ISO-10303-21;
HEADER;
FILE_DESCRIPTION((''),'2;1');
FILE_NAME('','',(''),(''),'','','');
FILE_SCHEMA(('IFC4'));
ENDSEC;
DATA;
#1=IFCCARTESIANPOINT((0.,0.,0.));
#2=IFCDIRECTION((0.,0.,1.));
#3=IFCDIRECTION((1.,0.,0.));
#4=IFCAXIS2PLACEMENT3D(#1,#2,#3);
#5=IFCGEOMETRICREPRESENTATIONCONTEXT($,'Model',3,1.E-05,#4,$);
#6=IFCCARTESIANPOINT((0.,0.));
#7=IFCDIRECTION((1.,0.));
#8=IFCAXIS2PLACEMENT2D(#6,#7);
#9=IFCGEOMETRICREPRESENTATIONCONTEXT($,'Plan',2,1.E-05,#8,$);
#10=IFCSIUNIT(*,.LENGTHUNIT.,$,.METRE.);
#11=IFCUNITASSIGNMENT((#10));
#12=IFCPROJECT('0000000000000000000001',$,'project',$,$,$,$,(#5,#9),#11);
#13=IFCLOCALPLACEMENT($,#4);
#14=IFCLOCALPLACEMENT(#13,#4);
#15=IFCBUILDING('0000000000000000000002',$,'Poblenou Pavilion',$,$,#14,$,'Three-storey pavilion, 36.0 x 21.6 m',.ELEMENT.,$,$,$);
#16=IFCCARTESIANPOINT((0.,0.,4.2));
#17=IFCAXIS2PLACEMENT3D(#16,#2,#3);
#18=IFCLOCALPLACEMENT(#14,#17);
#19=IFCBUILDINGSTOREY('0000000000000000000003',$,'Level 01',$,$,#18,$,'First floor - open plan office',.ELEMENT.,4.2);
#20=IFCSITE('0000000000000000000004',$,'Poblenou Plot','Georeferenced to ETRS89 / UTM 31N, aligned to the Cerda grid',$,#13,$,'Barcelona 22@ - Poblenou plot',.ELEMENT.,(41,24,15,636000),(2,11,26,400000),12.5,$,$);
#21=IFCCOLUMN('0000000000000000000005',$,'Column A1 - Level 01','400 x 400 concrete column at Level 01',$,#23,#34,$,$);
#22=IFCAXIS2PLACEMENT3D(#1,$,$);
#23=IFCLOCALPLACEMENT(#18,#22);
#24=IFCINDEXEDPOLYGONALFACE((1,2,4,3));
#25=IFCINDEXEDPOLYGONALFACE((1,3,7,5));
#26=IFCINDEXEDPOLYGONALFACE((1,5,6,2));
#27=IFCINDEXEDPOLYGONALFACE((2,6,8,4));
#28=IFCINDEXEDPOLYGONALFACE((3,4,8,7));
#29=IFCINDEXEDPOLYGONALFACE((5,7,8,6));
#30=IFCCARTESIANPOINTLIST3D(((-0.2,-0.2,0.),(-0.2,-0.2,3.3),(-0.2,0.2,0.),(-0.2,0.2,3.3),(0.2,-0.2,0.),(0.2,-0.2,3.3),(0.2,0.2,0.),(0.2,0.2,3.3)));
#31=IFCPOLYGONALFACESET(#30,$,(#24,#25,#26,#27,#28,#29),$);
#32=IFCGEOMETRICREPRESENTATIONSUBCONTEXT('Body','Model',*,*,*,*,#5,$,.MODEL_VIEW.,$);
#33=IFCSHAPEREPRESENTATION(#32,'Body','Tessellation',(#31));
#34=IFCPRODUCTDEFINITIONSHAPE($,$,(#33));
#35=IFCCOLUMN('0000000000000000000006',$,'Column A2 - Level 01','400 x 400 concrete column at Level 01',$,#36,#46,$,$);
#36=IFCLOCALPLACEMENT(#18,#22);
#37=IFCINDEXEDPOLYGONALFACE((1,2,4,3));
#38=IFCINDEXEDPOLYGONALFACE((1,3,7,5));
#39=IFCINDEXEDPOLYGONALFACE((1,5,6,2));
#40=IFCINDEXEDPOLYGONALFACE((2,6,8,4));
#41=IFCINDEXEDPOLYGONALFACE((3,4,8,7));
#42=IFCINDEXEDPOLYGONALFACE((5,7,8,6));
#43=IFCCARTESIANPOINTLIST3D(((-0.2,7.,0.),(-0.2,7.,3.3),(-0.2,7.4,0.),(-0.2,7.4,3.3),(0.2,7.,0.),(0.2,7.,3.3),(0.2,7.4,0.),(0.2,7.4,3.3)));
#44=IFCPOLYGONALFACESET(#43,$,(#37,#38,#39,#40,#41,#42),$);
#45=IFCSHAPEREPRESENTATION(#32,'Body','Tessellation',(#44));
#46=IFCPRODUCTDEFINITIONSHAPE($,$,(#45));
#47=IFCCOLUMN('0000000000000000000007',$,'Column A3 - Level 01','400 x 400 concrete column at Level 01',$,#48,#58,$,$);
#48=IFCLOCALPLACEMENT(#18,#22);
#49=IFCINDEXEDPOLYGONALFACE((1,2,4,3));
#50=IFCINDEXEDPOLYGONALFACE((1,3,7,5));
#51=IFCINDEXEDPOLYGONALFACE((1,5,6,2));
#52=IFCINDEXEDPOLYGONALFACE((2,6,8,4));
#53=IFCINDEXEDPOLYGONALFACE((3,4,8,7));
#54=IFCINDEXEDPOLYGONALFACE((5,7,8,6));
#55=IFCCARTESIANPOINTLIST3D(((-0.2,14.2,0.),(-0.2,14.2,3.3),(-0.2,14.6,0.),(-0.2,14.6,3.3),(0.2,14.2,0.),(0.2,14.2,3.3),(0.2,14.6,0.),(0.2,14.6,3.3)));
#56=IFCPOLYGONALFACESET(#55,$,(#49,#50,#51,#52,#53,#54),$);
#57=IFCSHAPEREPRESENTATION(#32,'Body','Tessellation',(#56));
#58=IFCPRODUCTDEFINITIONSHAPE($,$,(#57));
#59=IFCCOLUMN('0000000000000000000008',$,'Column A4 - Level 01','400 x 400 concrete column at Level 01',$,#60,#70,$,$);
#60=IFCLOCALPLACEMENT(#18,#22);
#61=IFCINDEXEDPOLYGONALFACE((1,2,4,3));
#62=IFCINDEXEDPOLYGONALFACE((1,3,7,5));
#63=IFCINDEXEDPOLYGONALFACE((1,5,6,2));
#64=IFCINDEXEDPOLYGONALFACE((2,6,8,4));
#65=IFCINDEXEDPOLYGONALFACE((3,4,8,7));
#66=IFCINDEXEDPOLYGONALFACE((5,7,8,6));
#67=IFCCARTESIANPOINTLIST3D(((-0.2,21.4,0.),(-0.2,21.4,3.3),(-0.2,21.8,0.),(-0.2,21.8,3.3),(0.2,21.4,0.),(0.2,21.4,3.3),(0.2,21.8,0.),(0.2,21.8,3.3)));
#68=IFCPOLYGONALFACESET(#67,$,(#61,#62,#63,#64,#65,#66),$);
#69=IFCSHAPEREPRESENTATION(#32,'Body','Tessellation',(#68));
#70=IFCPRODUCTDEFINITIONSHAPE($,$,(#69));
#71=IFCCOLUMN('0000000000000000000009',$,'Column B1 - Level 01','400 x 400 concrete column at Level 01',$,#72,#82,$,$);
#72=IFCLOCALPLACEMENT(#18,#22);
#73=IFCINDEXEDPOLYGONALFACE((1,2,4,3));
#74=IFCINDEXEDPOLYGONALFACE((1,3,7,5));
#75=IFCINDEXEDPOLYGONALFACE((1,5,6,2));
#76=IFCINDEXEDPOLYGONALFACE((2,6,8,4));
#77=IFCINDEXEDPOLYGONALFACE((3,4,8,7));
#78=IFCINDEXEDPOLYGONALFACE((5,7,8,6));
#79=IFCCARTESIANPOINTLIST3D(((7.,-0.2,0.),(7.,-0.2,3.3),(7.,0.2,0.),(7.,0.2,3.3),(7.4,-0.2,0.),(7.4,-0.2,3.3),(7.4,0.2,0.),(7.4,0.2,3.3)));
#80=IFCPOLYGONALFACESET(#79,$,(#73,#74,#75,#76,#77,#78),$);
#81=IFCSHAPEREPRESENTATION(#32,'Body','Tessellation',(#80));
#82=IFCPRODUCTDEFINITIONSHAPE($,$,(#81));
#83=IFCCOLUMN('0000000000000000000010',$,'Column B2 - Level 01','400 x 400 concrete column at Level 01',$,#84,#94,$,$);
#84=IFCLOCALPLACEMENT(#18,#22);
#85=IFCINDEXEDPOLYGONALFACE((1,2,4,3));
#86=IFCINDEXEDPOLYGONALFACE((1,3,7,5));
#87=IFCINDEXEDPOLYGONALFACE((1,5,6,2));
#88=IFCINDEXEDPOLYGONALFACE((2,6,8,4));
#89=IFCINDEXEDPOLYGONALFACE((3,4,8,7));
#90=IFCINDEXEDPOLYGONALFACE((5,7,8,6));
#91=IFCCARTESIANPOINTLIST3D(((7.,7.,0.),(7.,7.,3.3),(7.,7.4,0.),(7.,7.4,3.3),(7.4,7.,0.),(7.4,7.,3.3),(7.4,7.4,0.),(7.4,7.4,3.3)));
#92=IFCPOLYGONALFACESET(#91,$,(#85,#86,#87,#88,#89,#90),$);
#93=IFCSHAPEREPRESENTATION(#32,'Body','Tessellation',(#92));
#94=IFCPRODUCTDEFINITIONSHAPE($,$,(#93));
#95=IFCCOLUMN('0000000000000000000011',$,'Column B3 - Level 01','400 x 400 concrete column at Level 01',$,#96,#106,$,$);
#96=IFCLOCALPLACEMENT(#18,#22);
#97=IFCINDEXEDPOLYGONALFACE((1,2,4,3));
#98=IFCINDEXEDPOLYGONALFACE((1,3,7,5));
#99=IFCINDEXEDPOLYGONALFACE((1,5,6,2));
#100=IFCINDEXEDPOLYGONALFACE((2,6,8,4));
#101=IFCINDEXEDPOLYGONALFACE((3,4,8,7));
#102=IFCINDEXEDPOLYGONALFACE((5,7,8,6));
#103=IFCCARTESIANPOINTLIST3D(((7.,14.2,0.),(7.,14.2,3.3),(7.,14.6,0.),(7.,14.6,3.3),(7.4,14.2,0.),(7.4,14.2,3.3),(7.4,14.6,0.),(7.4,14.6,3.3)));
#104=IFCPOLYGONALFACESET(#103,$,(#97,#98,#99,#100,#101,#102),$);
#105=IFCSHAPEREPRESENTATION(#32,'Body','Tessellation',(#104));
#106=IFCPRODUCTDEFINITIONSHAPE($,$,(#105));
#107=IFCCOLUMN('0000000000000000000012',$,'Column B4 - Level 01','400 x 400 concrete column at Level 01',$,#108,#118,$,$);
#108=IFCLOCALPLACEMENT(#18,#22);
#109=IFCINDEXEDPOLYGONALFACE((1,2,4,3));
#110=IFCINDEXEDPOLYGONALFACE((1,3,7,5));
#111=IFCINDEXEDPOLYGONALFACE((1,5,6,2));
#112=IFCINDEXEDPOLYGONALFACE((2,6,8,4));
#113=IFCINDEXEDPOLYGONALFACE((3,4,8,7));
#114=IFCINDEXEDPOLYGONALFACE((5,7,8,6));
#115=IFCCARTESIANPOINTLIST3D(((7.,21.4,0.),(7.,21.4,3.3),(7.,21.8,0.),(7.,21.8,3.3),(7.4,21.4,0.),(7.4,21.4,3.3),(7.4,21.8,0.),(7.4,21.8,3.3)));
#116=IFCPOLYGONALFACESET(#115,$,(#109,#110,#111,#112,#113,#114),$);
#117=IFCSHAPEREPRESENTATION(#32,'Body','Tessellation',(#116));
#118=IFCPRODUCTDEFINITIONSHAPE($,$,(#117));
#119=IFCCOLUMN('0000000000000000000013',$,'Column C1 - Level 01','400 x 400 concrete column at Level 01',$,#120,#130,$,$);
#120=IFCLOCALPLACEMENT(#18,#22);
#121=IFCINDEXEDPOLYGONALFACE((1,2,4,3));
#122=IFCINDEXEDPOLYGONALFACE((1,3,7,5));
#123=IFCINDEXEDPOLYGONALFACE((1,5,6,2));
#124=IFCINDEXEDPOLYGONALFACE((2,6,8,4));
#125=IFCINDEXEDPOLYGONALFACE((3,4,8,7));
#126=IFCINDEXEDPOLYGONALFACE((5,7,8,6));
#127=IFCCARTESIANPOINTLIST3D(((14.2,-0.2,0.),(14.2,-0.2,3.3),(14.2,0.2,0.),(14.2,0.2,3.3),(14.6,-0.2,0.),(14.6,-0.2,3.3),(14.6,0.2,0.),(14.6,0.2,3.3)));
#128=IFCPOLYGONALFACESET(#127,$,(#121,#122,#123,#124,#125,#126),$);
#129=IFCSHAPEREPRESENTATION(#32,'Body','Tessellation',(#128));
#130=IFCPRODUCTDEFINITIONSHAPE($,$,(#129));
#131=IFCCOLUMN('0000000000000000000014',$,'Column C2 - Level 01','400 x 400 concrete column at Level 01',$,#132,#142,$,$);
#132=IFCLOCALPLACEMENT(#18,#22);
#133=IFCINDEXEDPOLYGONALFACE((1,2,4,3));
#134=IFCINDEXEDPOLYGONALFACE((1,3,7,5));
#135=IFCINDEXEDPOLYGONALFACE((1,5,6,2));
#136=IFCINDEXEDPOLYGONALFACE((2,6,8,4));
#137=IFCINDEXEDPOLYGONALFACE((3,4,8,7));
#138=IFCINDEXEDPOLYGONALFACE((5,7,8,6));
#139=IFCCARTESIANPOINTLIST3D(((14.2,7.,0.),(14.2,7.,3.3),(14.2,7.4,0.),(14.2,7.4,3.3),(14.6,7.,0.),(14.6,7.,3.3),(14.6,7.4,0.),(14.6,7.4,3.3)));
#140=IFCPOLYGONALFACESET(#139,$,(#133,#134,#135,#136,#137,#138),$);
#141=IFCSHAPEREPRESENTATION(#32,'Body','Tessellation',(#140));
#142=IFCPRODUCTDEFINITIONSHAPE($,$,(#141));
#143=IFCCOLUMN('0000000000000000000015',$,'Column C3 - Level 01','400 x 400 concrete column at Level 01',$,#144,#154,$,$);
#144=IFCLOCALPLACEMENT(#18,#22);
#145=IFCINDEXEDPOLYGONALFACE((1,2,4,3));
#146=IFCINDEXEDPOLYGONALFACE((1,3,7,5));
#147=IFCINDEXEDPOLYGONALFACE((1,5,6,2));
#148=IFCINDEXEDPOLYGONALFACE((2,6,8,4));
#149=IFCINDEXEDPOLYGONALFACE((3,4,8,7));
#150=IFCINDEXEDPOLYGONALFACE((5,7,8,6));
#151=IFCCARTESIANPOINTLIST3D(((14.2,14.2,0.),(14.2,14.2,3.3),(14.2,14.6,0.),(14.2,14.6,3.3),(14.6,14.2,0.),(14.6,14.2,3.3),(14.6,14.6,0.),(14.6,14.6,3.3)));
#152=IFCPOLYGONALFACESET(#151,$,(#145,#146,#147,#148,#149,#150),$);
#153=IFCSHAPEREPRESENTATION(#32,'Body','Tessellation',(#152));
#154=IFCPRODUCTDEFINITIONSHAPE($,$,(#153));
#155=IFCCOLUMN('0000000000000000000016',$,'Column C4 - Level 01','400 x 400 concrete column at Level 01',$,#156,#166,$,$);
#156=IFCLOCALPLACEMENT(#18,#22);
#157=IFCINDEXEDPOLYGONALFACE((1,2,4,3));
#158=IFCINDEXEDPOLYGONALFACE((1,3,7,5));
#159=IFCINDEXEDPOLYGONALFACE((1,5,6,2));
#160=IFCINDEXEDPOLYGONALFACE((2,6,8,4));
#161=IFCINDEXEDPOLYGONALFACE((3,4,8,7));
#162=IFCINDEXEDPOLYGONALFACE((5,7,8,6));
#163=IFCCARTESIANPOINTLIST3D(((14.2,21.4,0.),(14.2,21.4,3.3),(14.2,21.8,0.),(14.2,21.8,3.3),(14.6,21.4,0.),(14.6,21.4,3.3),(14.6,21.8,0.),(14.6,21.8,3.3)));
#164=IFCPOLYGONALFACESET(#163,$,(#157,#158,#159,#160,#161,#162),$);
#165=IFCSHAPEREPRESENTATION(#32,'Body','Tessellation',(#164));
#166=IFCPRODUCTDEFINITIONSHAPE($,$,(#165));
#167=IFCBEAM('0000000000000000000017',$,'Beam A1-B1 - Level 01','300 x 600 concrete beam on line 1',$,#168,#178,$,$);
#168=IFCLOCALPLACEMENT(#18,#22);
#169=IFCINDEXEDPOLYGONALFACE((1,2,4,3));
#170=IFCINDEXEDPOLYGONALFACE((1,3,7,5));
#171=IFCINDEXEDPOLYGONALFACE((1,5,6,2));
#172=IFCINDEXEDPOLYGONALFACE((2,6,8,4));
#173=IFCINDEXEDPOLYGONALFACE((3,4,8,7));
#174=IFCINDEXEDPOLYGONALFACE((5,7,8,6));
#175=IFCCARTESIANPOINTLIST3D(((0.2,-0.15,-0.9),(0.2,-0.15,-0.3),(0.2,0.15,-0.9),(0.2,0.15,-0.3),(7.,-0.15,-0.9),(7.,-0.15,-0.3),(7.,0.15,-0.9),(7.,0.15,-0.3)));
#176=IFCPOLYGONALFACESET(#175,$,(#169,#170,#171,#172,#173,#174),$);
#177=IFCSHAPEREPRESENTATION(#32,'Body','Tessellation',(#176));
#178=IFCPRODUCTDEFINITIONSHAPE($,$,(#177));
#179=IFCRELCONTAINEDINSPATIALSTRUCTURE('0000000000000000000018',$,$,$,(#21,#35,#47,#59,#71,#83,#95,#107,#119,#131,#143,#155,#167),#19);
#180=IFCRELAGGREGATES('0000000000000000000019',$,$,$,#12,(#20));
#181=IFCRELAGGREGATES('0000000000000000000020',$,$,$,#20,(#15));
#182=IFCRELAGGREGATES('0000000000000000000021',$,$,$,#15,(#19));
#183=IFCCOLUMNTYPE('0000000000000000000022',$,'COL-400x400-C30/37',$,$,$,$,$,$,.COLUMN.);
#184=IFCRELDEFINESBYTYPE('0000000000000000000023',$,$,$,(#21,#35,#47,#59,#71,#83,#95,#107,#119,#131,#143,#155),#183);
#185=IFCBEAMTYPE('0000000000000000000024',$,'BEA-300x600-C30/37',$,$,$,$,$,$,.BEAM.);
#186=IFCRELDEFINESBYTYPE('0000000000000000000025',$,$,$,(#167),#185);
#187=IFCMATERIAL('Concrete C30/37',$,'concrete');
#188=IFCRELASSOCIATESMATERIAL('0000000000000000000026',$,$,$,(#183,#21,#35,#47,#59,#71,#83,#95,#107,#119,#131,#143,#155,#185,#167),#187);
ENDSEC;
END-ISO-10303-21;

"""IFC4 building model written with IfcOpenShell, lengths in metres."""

from ifc_helpers import new_model, si_unit, frame, origin_with_axes, origin_2d_with_axis, place, context, subcontext, project, spatial, line, indexed_curve, rectangle, outline, extrude, material, material_profile, profile_set, profile_usage, type_object, element, save


model = new_model("IFC4")

# Units and contexts
model_context = context("Model", 3, precision=1e-05, world=origin_with_axes())
plan_context = context("Plan", 2, precision=1e-05, world=origin_2d_with_axis())
body_context = subcontext(model_context, "Body", "Model", "MODEL_VIEW")
ifc_project = project(units=[si_unit("LENGTHUNIT", "METRE")], contexts=[model_context, plan_context])

# Site, building, storey
site_placement = place(None, origin_with_axes())
site = spatial("IfcSite", under=ifc_project, at=site_placement, Name="Poblenou Plot", Description="Georeferenced to ETRS89 / UTM 31N, aligned to the Cerda grid", LongName="Barcelona 22@ - Poblenou plot", CompositionType="ELEMENT", RefLatitude=(41, 24, 15, 636000), RefLongitude=(2, 11, 26, 400000), RefElevation=12.5)
building_placement = place(site_placement, origin_with_axes())
building = spatial("IfcBuilding", under=site, at=building_placement, Name="Poblenou Pavilion", LongName="Three-storey pavilion, 36.0 x 21.6 m", CompositionType="ELEMENT")
storey_placement = place(building_placement, frame((0.0, 0.0, 4.2), z_axis=(0.0, 0.0, 1.0), x_axis=(1.0, 0.0, 0.0)))
storey = spatial("IfcBuildingStorey", under=building, at=storey_placement, Name="Level 01", LongName="First floor - open plan office", CompositionType="ELEMENT", Elevation=4.2)

# Columns
ifc_material = material(Name="Concrete C30/37", Category="concrete")
ifc_material_profile_1 = material_profile(ifc_material, rectangle(XDim=0.4, YDim=0.4))
ifc_profile_set_1 = profile_set([ifc_material_profile_1], Name="COL-400x400-C30/37")
ifc_profile_usage_1 = profile_usage(ifc_profile_set_1)
column_type = type_object("IfcColumnType", Name="COL-400x400-C30/37", PredefinedType="COLUMN", material=ifc_profile_set_1)
column_1_placement = place(storey_placement, frame((-0.2, -0.2, 0.0), z_axis=(0.0, 0.0, 1.0), x_axis=(1.0, 0.0, 0.0)))
element("IfcColumn", 1, at=column_1_placement, inside=storey, type_object=column_type, material=ifc_profile_usage_1, Name="Column A1 - Level 01", Description="400 x 400 concrete column at Level 01", context=body_context, shape_type="SweptSolid", body=[
    extrude(outline(indexed_curve([(0.0, 0.0), (0.4, 0.0), (0.4, 0.4), (0.0, 0.4)], segments=[line(1, 2, 3, 4, 1)])), origin_with_axes(), (0.0, 0.0, 1.0), 3.3),
])
ifc_profile_usage_2 = profile_usage(ifc_profile_set_1)
column_2_placement = place(storey_placement, frame((-0.2, 7.0, 0.0), z_axis=(0.0, 0.0, 1.0), x_axis=(1.0, 0.0, 0.0)))
element("IfcColumn", 2, at=column_2_placement, inside=storey, type_object=column_type, material=ifc_profile_usage_2, Name="Column A2 - Level 01", Description="400 x 400 concrete column at Level 01", context=body_context, shape_type="SweptSolid", body=[
    extrude(outline(indexed_curve([(0.0, 0.0), (0.4, 0.0), (0.4, 0.4), (0.0, 0.4)], segments=[line(1, 2, 3, 4, 1)])), origin_with_axes(), (0.0, 0.0, 1.0), 3.3),
])
ifc_profile_usage_3 = profile_usage(ifc_profile_set_1)
column_3_placement = place(storey_placement, frame((-0.2, 14.2, 0.0), z_axis=(0.0, 0.0, 1.0), x_axis=(1.0, 0.0, 0.0)))
element("IfcColumn", 3, at=column_3_placement, inside=storey, type_object=column_type, material=ifc_profile_usage_3, Name="Column A3 - Level 01", Description="400 x 400 concrete column at Level 01", context=body_context, shape_type="SweptSolid", body=[
    extrude(outline(indexed_curve([(0.0, 0.0), (0.4, 0.0), (0.4, 0.4), (0.0, 0.4)], segments=[line(1, 2, 3, 4, 1)])), origin_with_axes(), (0.0, 0.0, 1.0), 3.3),
])
ifc_profile_usage_4 = profile_usage(ifc_profile_set_1)
column_4_placement = place(storey_placement, frame((-0.2, 21.4, 0.0), z_axis=(0.0, 0.0, 1.0), x_axis=(1.0, 0.0, 0.0)))
element("IfcColumn", 4, at=column_4_placement, inside=storey, type_object=column_type, material=ifc_profile_usage_4, Name="Column A4 - Level 01", Description="400 x 400 concrete column at Level 01", context=body_context, shape_type="SweptSolid", body=[
    extrude(outline(indexed_curve([(0.0, 0.0), (0.4, 0.0), (0.4, 0.4), (0.0, 0.4)], segments=[line(1, 2, 3, 4, 1)])), origin_with_axes(), (0.0, 0.0, 1.0), 3.3),
])
ifc_profile_usage_5 = profile_usage(ifc_profile_set_1)
column_5_placement = place(storey_placement, frame((7.0, -0.2, 0.0), z_axis=(0.0, 0.0, 1.0), x_axis=(1.0, 0.0, 0.0)))
element("IfcColumn", 5, at=column_5_placement, inside=storey, type_object=column_type, material=ifc_profile_usage_5, Name="Column B1 - Level 01", Description="400 x 400 concrete column at Level 01", context=body_context, shape_type="SweptSolid", body=[
    extrude(outline(indexed_curve([(0.0, 0.0), (0.4, 0.0), (0.4, 0.4), (0.0, 0.4)], segments=[line(1, 2, 3, 4, 1)])), origin_with_axes(), (0.0, 0.0, 1.0), 3.3),
])
ifc_profile_usage_6 = profile_usage(ifc_profile_set_1)
column_6_placement = place(storey_placement, frame((7.0, 7.0, 0.0), z_axis=(0.0, 0.0, 1.0), x_axis=(1.0, 0.0, 0.0)))
element("IfcColumn", 6, at=column_6_placement, inside=storey, type_object=column_type, material=ifc_profile_usage_6, Name="Column B2 - Level 01", Description="400 x 400 concrete column at Level 01", context=body_context, shape_type="SweptSolid", body=[
    extrude(outline(indexed_curve([(0.0, 0.0), (0.4, 0.0), (0.4, 0.4), (0.0, 0.4)], segments=[line(1, 2, 3, 4, 1)])), origin_with_axes(), (0.0, 0.0, 1.0), 3.3),
])
ifc_profile_usage_7 = profile_usage(ifc_profile_set_1)
column_7_placement = place(storey_placement, frame((7.0, 14.2, 0.0), z_axis=(0.0, 0.0, 1.0), x_axis=(1.0, 0.0, 0.0)))
element("IfcColumn", 7, at=column_7_placement, inside=storey, type_object=column_type, material=ifc_profile_usage_7, Name="Column B3 - Level 01", Description="400 x 400 concrete column at Level 01", context=body_context, shape_type="SweptSolid", body=[
    extrude(outline(indexed_curve([(0.0, 0.0), (0.4, 0.0), (0.4, 0.4), (0.0, 0.4)], segments=[line(1, 2, 3, 4, 1)])), origin_with_axes(), (0.0, 0.0, 1.0), 3.3),
])
ifc_profile_usage_8 = profile_usage(ifc_profile_set_1)
column_8_placement = place(storey_placement, frame((7.0, 21.4, 0.0), z_axis=(0.0, 0.0, 1.0), x_axis=(1.0, 0.0, 0.0)))
element("IfcColumn", 8, at=column_8_placement, inside=storey, type_object=column_type, material=ifc_profile_usage_8, Name="Column B4 - Level 01", Description="400 x 400 concrete column at Level 01", context=body_context, shape_type="SweptSolid", body=[
    extrude(outline(indexed_curve([(0.0, 0.0), (0.4, 0.0), (0.4, 0.4), (0.0, 0.4)], segments=[line(1, 2, 3, 4, 1)])), origin_with_axes(), (0.0, 0.0, 1.0), 3.3),
])
ifc_profile_usage_9 = profile_usage(ifc_profile_set_1)
column_9_placement = place(storey_placement, frame((14.2, -0.2, 0.0), z_axis=(0.0, 0.0, 1.0), x_axis=(1.0, 0.0, 0.0)))
element("IfcColumn", 9, at=column_9_placement, inside=storey, type_object=column_type, material=ifc_profile_usage_9, Name="Column C1 - Level 01", Description="400 x 400 concrete column at Level 01", context=body_context, shape_type="SweptSolid", body=[
    extrude(outline(indexed_curve([(0.0, 0.0), (0.4, 0.0), (0.4, 0.4), (0.0, 0.4)], segments=[line(1, 2, 3, 4, 1)])), origin_with_axes(), (0.0, 0.0, 1.0), 3.3),
])
ifc_profile_usage_10 = profile_usage(ifc_profile_set_1)
column_10_placement = place(storey_placement, frame((14.2, 7.0, 0.0), z_axis=(0.0, 0.0, 1.0), x_axis=(1.0, 0.0, 0.0)))
element("IfcColumn", 10, at=column_10_placement, inside=storey, type_object=column_type, material=ifc_profile_usage_10, Name="Column C2 - Level 01", Description="400 x 400 concrete column at Level 01", context=body_context, shape_type="SweptSolid", body=[
    extrude(outline(indexed_curve([(0.0, 0.0), (0.4, 0.0), (0.4, 0.4), (0.0, 0.4)], segments=[line(1, 2, 3, 4, 1)])), origin_with_axes(), (0.0, 0.0, 1.0), 3.3),
])
ifc_profile_usage_11 = profile_usage(ifc_profile_set_1)
column_11_placement = place(storey_placement, frame((14.2, 14.2, 0.0), z_axis=(0.0, 0.0, 1.0), x_axis=(1.0, 0.0, 0.0)))
element("IfcColumn", 11, at=column_11_placement, inside=storey, type_object=column_type, material=ifc_profile_usage_11, Name="Column C3 - Level 01", Description="400 x 400 concrete column at Level 01", context=body_context, shape_type="SweptSolid", body=[
    extrude(outline(indexed_curve([(0.0, 0.0), (0.4, 0.0), (0.4, 0.4), (0.0, 0.4)], segments=[line(1, 2, 3, 4, 1)])), origin_with_axes(), (0.0, 0.0, 1.0), 3.3),
])
ifc_profile_usage_12 = profile_usage(ifc_profile_set_1)
column_12_placement = place(storey_placement, frame((14.2, 21.4, 0.0), z_axis=(0.0, 0.0, 1.0), x_axis=(1.0, 0.0, 0.0)))
element("IfcColumn", 12, at=column_12_placement, inside=storey, type_object=column_type, material=ifc_profile_usage_12, Name="Column C4 - Level 01", Description="400 x 400 concrete column at Level 01", context=body_context, shape_type="SweptSolid", body=[
    extrude(outline(indexed_curve([(0.0, 0.0), (0.4, 0.0), (0.4, 0.4), (0.0, 0.4)], segments=[line(1, 2, 3, 4, 1)])), origin_with_axes(), (0.0, 0.0, 1.0), 3.3),
])

# Beam
ifc_material_profile_2 = material_profile(ifc_material, rectangle(XDim=0.3, YDim=0.6))
ifc_profile_set_2 = profile_set([ifc_material_profile_2], Name="BEA-300x600-C30/37")
ifc_profile_usage_13 = profile_usage(ifc_profile_set_2)
beam_type = type_object("IfcBeamType", Name="BEA-300x600-C30/37", PredefinedType="BEAM", material=ifc_profile_set_2)
beam_1_placement = place(storey_placement, frame((0.2, -0.15, -0.9), z_axis=(1.0, 0.0, 0.0), x_axis=(0.0, 1.0, 0.0)))
element("IfcBeam", 13, at=beam_1_placement, inside=storey, type_object=beam_type, material=ifc_profile_usage_13, Name="Beam A1-B1 - Level 01", Description="300 x 600 concrete beam on line 1", context=body_context, shape_type="SweptSolid", body=[
    extrude(outline(indexed_curve([(0.0, 0.0), (0.3, 0.0), (0.3, 0.6), (0.0, 0.6)], segments=[line(1, 2, 3, 4, 1)])), origin_with_axes(), (0.0, 0.0, 1.0), 6.8),
])

save(model, "model.ifc")
